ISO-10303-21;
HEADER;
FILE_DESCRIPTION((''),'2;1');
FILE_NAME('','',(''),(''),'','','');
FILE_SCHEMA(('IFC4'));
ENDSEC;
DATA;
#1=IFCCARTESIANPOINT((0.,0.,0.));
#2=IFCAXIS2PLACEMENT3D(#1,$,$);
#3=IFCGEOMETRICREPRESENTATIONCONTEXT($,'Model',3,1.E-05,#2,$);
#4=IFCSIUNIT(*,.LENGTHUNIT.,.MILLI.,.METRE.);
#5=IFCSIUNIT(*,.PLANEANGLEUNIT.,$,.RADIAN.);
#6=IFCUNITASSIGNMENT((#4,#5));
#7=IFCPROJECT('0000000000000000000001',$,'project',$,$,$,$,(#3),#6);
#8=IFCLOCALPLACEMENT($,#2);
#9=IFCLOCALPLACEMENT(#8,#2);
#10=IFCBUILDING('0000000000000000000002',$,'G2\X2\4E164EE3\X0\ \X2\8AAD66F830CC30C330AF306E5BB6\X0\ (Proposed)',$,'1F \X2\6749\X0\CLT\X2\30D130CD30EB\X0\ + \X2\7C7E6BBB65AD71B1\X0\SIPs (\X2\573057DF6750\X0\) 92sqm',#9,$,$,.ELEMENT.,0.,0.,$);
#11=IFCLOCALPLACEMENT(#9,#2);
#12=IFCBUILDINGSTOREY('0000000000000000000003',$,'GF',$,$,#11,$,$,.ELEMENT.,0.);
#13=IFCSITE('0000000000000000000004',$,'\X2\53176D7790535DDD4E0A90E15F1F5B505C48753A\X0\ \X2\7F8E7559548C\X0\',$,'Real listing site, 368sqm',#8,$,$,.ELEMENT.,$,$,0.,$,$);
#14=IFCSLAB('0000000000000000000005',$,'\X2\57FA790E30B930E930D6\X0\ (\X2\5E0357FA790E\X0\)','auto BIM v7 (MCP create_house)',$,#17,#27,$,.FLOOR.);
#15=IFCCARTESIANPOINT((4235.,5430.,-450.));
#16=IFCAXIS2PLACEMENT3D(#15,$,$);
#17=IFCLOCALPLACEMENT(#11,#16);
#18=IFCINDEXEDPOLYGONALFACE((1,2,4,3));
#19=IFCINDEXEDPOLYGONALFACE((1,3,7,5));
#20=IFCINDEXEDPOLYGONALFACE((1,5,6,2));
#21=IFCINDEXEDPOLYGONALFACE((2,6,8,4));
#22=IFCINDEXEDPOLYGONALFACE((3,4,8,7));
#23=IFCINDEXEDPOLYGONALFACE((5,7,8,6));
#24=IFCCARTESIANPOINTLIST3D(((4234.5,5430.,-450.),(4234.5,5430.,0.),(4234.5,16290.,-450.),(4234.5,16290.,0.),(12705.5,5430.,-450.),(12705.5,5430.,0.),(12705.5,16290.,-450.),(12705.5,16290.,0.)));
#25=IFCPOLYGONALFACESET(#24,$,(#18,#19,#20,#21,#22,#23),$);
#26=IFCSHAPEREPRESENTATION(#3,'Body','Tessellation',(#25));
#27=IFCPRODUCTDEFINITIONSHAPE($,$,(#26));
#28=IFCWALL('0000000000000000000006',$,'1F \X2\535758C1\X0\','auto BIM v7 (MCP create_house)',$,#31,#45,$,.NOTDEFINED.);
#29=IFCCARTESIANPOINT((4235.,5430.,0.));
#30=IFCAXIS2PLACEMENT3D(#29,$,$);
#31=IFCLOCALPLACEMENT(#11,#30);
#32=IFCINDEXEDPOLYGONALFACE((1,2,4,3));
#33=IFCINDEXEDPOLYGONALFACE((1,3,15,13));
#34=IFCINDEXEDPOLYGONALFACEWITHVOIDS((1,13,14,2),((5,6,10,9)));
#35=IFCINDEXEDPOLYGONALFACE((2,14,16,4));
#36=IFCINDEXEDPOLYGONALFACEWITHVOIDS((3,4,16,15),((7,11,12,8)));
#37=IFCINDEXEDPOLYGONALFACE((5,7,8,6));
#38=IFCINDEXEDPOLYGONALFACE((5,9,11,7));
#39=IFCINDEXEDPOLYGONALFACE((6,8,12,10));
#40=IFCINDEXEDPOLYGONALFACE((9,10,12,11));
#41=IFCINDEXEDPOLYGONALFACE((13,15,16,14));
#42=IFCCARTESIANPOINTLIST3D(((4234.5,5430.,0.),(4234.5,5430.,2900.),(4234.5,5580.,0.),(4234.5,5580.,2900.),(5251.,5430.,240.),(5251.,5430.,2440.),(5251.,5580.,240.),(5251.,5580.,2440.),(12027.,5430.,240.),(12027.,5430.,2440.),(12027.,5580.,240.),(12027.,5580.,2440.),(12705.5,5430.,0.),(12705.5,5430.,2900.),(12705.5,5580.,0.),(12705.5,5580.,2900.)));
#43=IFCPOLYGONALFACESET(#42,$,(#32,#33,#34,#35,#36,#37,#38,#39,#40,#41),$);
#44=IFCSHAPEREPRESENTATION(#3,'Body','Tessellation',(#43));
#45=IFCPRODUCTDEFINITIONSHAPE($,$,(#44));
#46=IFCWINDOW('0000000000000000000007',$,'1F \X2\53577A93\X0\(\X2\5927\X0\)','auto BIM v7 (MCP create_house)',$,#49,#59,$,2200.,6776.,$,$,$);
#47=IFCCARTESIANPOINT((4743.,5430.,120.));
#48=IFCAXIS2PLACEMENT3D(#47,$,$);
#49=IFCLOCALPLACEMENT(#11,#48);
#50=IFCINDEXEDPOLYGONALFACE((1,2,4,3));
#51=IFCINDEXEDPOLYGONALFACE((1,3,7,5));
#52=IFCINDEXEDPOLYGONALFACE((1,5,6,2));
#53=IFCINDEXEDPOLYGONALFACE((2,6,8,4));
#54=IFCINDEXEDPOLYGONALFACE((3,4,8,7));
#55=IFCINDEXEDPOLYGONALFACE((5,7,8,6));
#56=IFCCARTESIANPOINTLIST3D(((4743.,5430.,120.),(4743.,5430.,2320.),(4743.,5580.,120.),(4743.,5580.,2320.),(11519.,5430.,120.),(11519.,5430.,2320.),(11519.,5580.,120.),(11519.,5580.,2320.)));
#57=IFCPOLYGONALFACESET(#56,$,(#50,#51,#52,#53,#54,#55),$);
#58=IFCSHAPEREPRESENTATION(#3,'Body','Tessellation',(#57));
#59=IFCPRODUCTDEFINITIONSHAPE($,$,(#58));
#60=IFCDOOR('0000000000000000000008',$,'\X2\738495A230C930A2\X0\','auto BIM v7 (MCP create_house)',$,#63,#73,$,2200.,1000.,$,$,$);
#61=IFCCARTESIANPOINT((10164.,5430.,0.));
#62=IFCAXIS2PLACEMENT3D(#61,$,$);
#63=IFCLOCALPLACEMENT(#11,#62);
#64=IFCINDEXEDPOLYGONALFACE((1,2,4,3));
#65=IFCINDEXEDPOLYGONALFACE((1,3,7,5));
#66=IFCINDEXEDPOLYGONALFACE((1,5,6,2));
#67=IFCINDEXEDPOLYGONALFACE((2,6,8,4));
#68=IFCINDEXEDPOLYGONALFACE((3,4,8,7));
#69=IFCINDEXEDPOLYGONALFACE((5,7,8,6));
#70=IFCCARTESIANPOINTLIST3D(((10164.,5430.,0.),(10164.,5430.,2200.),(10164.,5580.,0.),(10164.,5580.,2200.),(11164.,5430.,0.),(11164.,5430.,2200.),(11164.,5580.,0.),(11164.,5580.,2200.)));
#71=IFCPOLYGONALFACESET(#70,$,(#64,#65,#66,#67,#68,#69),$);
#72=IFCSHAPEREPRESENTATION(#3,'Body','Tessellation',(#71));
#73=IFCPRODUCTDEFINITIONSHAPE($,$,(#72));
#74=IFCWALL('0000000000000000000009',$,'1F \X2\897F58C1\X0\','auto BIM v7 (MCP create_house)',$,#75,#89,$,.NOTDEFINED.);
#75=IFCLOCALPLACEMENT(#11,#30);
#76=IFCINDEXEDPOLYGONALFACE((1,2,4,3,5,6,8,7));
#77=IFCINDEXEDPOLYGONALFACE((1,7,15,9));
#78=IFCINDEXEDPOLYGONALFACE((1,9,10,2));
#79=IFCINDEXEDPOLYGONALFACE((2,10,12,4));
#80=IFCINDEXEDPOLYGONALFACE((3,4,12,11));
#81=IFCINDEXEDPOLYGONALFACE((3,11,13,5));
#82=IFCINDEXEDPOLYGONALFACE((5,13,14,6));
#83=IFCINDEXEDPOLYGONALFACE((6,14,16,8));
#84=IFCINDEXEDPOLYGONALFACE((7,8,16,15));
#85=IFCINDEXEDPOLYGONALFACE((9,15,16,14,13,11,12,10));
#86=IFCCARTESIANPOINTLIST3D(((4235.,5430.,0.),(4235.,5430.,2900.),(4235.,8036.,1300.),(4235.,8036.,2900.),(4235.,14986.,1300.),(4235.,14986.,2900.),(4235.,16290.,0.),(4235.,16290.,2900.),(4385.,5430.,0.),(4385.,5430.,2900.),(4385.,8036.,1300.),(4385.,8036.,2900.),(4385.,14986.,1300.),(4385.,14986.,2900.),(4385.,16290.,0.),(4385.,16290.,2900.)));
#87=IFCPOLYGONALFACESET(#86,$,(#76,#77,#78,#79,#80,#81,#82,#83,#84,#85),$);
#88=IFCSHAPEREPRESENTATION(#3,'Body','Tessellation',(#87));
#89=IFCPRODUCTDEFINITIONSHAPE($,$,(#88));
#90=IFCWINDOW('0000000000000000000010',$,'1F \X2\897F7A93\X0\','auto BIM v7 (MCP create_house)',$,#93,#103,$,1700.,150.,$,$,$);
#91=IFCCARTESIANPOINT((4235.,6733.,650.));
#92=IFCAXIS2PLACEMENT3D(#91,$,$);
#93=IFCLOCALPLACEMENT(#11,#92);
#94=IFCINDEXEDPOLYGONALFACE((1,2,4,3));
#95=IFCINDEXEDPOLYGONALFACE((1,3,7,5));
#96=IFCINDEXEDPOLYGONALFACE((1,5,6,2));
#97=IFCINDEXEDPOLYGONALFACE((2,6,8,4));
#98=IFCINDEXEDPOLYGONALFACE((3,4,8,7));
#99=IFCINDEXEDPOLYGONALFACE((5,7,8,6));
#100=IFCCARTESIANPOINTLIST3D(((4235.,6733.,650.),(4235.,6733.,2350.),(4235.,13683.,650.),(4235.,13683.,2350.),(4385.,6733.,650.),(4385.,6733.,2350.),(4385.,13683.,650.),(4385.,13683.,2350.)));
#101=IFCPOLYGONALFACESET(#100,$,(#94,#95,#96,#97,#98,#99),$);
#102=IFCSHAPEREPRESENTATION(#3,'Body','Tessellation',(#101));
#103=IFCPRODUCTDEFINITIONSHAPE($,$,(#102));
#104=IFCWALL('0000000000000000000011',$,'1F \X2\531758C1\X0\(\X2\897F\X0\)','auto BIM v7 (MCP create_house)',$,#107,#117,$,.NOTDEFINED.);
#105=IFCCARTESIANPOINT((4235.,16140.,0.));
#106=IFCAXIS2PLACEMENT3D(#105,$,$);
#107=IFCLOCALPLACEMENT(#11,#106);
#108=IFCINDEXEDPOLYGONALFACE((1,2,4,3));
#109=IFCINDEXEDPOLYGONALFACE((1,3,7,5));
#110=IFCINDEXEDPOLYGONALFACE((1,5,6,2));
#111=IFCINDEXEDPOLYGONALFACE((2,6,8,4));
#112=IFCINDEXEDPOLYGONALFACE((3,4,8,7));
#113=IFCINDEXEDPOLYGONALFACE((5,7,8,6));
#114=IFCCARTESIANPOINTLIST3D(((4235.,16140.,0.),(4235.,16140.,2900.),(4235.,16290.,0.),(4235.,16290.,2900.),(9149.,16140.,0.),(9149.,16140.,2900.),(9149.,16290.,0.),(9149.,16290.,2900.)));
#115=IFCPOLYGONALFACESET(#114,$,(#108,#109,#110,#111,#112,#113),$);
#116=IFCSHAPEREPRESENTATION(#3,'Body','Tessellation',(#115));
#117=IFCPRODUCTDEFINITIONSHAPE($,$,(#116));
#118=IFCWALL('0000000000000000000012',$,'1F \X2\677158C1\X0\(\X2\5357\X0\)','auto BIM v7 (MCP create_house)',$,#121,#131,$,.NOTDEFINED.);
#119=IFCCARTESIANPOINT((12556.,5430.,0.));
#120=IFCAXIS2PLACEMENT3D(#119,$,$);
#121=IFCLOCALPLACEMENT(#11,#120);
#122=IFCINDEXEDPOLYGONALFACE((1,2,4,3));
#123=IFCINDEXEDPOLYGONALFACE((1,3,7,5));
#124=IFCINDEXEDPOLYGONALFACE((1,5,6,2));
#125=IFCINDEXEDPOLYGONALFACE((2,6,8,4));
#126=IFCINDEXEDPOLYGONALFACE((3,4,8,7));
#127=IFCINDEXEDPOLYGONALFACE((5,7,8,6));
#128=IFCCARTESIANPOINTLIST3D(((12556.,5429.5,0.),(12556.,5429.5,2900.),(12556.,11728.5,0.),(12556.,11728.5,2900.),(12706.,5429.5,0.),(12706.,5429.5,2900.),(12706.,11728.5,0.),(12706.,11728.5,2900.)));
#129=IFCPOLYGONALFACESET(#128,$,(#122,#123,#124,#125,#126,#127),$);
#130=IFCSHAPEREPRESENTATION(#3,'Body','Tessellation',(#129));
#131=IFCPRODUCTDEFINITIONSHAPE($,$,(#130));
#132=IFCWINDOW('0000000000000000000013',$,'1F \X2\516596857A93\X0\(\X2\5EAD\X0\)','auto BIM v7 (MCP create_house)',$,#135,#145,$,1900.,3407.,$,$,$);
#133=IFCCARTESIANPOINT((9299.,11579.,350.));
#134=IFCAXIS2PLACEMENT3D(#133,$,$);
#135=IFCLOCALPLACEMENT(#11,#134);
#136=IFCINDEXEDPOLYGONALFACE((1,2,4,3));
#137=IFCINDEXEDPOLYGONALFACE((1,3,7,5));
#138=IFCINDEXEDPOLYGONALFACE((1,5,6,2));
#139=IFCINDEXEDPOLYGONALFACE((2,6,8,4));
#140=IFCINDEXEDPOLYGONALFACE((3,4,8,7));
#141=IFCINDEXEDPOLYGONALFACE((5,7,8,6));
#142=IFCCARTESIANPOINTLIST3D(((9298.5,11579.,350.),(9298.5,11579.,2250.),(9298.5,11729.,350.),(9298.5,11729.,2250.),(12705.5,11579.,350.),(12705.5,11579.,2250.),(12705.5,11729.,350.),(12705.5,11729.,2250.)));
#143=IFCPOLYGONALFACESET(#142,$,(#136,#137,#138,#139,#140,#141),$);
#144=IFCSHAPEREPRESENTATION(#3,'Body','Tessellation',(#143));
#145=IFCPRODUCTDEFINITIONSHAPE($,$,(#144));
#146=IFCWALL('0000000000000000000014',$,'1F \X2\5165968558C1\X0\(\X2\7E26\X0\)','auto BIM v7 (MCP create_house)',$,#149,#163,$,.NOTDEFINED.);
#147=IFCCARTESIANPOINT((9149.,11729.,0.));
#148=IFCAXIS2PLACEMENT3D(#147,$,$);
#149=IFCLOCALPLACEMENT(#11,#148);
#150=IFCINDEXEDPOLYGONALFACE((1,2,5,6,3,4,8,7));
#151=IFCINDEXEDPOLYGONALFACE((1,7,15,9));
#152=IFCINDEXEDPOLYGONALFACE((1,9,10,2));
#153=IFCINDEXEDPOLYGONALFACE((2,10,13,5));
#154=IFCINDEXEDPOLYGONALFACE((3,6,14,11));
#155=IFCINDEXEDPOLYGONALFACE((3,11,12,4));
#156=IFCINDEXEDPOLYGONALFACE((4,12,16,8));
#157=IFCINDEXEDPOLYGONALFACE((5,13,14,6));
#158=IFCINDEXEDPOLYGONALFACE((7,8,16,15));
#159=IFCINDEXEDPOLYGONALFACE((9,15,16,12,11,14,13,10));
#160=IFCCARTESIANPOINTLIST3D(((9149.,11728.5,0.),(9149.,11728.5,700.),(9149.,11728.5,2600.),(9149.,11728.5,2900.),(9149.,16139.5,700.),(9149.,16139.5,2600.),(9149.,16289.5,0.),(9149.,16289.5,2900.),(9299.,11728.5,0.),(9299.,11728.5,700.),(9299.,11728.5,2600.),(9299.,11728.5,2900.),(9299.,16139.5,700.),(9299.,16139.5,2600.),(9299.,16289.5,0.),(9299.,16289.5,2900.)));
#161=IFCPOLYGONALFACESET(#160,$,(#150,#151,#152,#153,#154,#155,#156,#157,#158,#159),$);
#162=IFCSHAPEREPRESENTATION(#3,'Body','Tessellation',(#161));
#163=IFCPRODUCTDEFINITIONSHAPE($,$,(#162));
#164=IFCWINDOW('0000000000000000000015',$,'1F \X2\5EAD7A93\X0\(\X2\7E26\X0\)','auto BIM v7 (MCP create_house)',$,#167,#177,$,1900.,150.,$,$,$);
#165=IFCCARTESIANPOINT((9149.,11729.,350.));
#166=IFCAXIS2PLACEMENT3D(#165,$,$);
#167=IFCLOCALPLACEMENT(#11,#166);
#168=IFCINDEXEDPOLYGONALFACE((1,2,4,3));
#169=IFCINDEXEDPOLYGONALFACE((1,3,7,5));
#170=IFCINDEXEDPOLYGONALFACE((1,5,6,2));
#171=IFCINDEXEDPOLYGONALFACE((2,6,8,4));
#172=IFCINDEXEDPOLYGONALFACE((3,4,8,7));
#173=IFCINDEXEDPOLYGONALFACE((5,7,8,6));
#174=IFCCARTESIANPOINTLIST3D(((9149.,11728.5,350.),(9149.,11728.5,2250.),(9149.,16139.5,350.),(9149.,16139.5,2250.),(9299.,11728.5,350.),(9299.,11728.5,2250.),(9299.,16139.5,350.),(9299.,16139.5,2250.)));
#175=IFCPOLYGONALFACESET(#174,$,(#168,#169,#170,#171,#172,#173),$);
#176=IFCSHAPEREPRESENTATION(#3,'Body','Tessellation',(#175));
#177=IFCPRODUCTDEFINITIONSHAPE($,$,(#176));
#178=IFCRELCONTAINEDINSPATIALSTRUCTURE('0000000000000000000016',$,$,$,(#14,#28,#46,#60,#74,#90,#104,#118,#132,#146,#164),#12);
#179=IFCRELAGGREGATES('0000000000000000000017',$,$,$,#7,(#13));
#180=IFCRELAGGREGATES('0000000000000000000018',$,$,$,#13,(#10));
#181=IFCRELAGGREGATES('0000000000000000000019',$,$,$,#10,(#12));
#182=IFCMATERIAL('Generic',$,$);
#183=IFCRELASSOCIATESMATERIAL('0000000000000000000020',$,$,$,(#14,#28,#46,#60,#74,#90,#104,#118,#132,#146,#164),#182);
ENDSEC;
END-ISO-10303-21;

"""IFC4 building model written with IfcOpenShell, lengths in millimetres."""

from ifc_helpers import new_model, si_unit, frame, frame_2d, origin, place, context, project, spatial, rectangle, extrude, material, element, fill, save


model = new_model("IFC4")

# Units and contexts
model_context = context("Model", 3, precision=1e-05, world=origin())
ifc_project = project(units=[si_unit("LENGTHUNIT", "METRE", prefix="MILLI"), si_unit("PLANEANGLEUNIT", "RADIAN")], contexts=[model_context])

# Site, building, storey
site_placement = place(None, origin())
site = spatial("IfcSite", under=ifc_project, at=site_placement, Name="北海道川上郡弟子屈町 美留和", ObjectType="Real listing site, 368sqm", CompositionType="ELEMENT", RefElevation=0.0)
building_placement = place(site_placement, origin())
building = spatial("IfcBuilding", under=site, at=building_placement, Name="G2世代 読書ヌックの家 (Proposed)", ObjectType="1F 杉CLTパネル + 籾殻断熱SIPs (地域材) 92sqm", CompositionType="ELEMENT", ElevationOfRefHeight=0.0, ElevationOfTerrain=0.0)
storey_placement = place(building_placement, origin())
storey = spatial("IfcBuildingStorey", under=building, at=storey_placement, Name="GF", CompositionType="ELEMENT", Elevation=0.0)

# Slab
ifc_material = material(Name="Generic")
slab_1_placement = place(storey_placement, frame((4235.0, 5430.0, -450.0)))
element("IfcSlab", 1, at=slab_1_placement, inside=storey, material=ifc_material, Name="基礎スラブ (布基礎)", Description="auto BIM v7 (MCP create_house)", PredefinedType="FLOOR", context=model_context, shape_type="SweptSolid", body=[
    extrude(rectangle(XDim=8471.0, YDim=10860.0, at=frame_2d((4235.0, 5430.0))), frame((4235.0, 5430.0, -450.0)), (0.0, 0.0, 1.0), 450.0),
])

# Wall, openings, window, door
wall_1_placement = place(storey_placement, frame((4235.0, 5430.0, 0.0)))
wall_1 = element("IfcWall", 2, at=wall_1_placement, inside=storey, material=ifc_material, Name="1F 南壁", Description="auto BIM v7 (MCP create_house)", PredefinedType="NOTDEFINED", context=model_context, shape_type="SweptSolid", body=[
    extrude(rectangle(XDim=8471.0, YDim=150.0, at=frame_2d((4235.0, 75.0))), frame((4235.0, 5430.0, 0.0)), (0.0, 0.0, 1.0), 2900.0),
])
opening_1_placement = place(storey_placement, frame((4743.0, 5430.0, 120.0)))
opening_1 = element("IfcOpeningElement", 3, at=opening_1_placement, cuts=wall_1, PredefinedType="NOTDEFINED", context=model_context, shape_type="SweptSolid", body=[
    extrude(rectangle(XDim=6776.0, YDim=150.0, at=frame_2d((3388.0, 75.0))), frame((4743.0, 5430.0, 120.0)), (0.0, 0.0, 1.0), 2200.0),
])
opening_2_placement = place(storey_placement, frame((10164.0, 5430.0, 0.0)))
opening_2 = element("IfcOpeningElement", 4, at=opening_2_placement, cuts=wall_1, PredefinedType="NOTDEFINED", context=model_context, shape_type="SweptSolid", body=[
    extrude(rectangle(XDim=1000.0, YDim=150.0, at=frame_2d((500.0, 75.0))), frame((10164.0, 5430.0, 0.0)), (0.0, 0.0, 1.0), 2200.0),
])
window_1_placement = place(storey_placement, frame((4743.0, 5430.0, 120.0)))
window_1 = element("IfcWindow", 5, at=window_1_placement, inside=storey, material=ifc_material, Name="1F 南窓(大)", Description="auto BIM v7 (MCP create_house)", OverallHeight=2200.0, OverallWidth=6776.0, context=model_context, shape_type="SweptSolid", body=[
    extrude(rectangle(XDim=6776.0, YDim=150.0, at=frame_2d((3388.0, 75.0))), frame((4743.0, 5430.0, 120.0)), (0.0, 0.0, 1.0), 2200.0),
])
fill(opening_1, window_1)
door_placement = place(storey_placement, frame((10164.0, 5430.0, 0.0)))
door = element("IfcDoor", 6, at=door_placement, inside=storey, material=ifc_material, Name="玄関ドア", Description="auto BIM v7 (MCP create_house)", OverallHeight=2200.0, OverallWidth=1000.0, context=model_context, shape_type="SweptSolid", body=[
    extrude(rectangle(XDim=1000.0, YDim=150.0, at=frame_2d((500.0, 75.0))), frame((10164.0, 5430.0, 0.0)), (0.0, 0.0, 1.0), 2200.0),
])
fill(opening_2, door)

# Wall, opening, window
wall_2_placement = place(storey_placement, frame((4235.0, 5430.0, 0.0)))
wall_2 = element("IfcWall", 7, at=wall_2_placement, inside=storey, material=ifc_material, Name="1F 西壁", Description="auto BIM v7 (MCP create_house)", PredefinedType="NOTDEFINED", context=model_context, shape_type="SweptSolid", body=[
    extrude(rectangle(XDim=150.0, YDim=10860.0, at=frame_2d((75.0, 5430.0))), frame((4235.0, 5430.0, 0.0)), (0.0, 0.0, 1.0), 2900.0),
])
opening_3_placement = place(storey_placement, frame((4235.0, 6733.0, 650.0)))
opening_3 = element("IfcOpeningElement", 8, at=opening_3_placement, cuts=wall_2, PredefinedType="NOTDEFINED", context=model_context, shape_type="SweptSolid", body=[
    extrude(rectangle(XDim=150.0, YDim=6950.0, at=frame_2d((75.0, 3475.0))), frame((4235.0, 6733.0, 650.0)), (0.0, 0.0, 1.0), 1700.0),
])
window_2_placement = place(storey_placement, frame((4235.0, 6733.0, 650.0)))
window_2 = element("IfcWindow", 9, at=window_2_placement, inside=storey, material=ifc_material, Name="1F 西窓", Description="auto BIM v7 (MCP create_house)", OverallHeight=1700.0, OverallWidth=150.0, context=model_context, shape_type="SweptSolid", body=[
    extrude(rectangle(XDim=150.0, YDim=6950.0, at=frame_2d((75.0, 3475.0))), frame((4235.0, 6733.0, 650.0)), (0.0, 0.0, 1.0), 1700.0),
])
fill(opening_3, window_2)

# Wall
wall_3_placement = place(storey_placement, frame((4235.0, 16140.0, 0.0)))
element("IfcWall", 10, at=wall_3_placement, inside=storey, material=ifc_material, Name="1F 北壁(西)", Description="auto BIM v7 (MCP create_house)", PredefinedType="NOTDEFINED", context=model_context, shape_type="SweptSolid", body=[
    extrude(rectangle(XDim=4914.0, YDim=150.0, at=frame_2d((2457.0, 75.0))), frame((4235.0, 16140.0, 0.0)), (0.0, 0.0, 1.0), 2900.0),
])

# Wall, opening, window
wall_4_placement = place(storey_placement, frame((12556.0, 5430.0, 0.0)))
wall_4 = element("IfcWall", 11, at=wall_4_placement, inside=storey, material=ifc_material, Name="1F 東壁(南)", Description="auto BIM v7 (MCP create_house)", PredefinedType="NOTDEFINED", context=model_context, shape_type="SweptSolid", body=[
    extrude(rectangle(XDim=150.0, YDim=6299.0, at=frame_2d((75.0, 3149.0))), frame((12556.0, 5430.0, 0.0)), (0.0, 0.0, 1.0), 2900.0),
])
opening_4_placement = place(storey_placement, frame((9299.0, 11579.0, 350.0)))
opening_4 = element("IfcOpeningElement", 12, at=opening_4_placement, cuts=wall_4, PredefinedType="NOTDEFINED", context=model_context, shape_type="SweptSolid", body=[
    extrude(rectangle(XDim=3407.0, YDim=150.0, at=frame_2d((1703.0, 75.0))), frame((9299.0, 11579.0, 350.0)), (0.0, 0.0, 1.0), 1900.0),
])
window_3_placement = place(storey_placement, frame((9299.0, 11579.0, 350.0)))
window_3 = element("IfcWindow", 13, at=window_3_placement, inside=storey, material=ifc_material, Name="1F 入隅窓(庭)", Description="auto BIM v7 (MCP create_house)", OverallHeight=1900.0, OverallWidth=3407.0, context=model_context, shape_type="SweptSolid", body=[
    extrude(rectangle(XDim=3407.0, YDim=150.0, at=frame_2d((1703.0, 75.0))), frame((9299.0, 11579.0, 350.0)), (0.0, 0.0, 1.0), 1900.0),
])
fill(opening_4, window_3)

# Wall, opening, window
wall_5_placement = place(storey_placement, frame((9149.0, 11729.0, 0.0)))
wall_5 = element("IfcWall", 14, at=wall_5_placement, inside=storey, material=ifc_material, Name="1F 入隅壁(縦)", Description="auto BIM v7 (MCP create_house)", PredefinedType="NOTDEFINED", context=model_context, shape_type="SweptSolid", body=[
    extrude(rectangle(XDim=150.0, YDim=4561.0, at=frame_2d((75.0, 2280.0))), frame((9149.0, 11729.0, 0.0)), (0.0, 0.0, 1.0), 2900.0),
])
opening_5_placement = place(storey_placement, frame((9149.0, 11729.0, 350.0)))
opening_5 = element("IfcOpeningElement", 15, at=opening_5_placement, cuts=wall_5, PredefinedType="NOTDEFINED", context=model_context, shape_type="SweptSolid", body=[
    extrude(rectangle(XDim=150.0, YDim=4411.0, at=frame_2d((75.0, 2205.0))), frame((9149.0, 11729.0, 350.0)), (0.0, 0.0, 1.0), 1900.0),
])
window_4_placement = place(storey_placement, frame((9149.0, 11729.0, 350.0)))
window_4 = element("IfcWindow", 16, at=window_4_placement, inside=storey, material=ifc_material, Name="1F 庭窓(縦)", Description="auto BIM v7 (MCP create_house)", OverallHeight=1900.0, OverallWidth=150.0, context=model_context, shape_type="SweptSolid", body=[
    extrude(rectangle(XDim=150.0, YDim=4411.0, at=frame_2d((75.0, 2205.0))), frame((9149.0, 11729.0, 350.0)), (0.0, 0.0, 1.0), 1900.0),
])
fill(opening_5, window_4)

save(model, "model.ifc")
